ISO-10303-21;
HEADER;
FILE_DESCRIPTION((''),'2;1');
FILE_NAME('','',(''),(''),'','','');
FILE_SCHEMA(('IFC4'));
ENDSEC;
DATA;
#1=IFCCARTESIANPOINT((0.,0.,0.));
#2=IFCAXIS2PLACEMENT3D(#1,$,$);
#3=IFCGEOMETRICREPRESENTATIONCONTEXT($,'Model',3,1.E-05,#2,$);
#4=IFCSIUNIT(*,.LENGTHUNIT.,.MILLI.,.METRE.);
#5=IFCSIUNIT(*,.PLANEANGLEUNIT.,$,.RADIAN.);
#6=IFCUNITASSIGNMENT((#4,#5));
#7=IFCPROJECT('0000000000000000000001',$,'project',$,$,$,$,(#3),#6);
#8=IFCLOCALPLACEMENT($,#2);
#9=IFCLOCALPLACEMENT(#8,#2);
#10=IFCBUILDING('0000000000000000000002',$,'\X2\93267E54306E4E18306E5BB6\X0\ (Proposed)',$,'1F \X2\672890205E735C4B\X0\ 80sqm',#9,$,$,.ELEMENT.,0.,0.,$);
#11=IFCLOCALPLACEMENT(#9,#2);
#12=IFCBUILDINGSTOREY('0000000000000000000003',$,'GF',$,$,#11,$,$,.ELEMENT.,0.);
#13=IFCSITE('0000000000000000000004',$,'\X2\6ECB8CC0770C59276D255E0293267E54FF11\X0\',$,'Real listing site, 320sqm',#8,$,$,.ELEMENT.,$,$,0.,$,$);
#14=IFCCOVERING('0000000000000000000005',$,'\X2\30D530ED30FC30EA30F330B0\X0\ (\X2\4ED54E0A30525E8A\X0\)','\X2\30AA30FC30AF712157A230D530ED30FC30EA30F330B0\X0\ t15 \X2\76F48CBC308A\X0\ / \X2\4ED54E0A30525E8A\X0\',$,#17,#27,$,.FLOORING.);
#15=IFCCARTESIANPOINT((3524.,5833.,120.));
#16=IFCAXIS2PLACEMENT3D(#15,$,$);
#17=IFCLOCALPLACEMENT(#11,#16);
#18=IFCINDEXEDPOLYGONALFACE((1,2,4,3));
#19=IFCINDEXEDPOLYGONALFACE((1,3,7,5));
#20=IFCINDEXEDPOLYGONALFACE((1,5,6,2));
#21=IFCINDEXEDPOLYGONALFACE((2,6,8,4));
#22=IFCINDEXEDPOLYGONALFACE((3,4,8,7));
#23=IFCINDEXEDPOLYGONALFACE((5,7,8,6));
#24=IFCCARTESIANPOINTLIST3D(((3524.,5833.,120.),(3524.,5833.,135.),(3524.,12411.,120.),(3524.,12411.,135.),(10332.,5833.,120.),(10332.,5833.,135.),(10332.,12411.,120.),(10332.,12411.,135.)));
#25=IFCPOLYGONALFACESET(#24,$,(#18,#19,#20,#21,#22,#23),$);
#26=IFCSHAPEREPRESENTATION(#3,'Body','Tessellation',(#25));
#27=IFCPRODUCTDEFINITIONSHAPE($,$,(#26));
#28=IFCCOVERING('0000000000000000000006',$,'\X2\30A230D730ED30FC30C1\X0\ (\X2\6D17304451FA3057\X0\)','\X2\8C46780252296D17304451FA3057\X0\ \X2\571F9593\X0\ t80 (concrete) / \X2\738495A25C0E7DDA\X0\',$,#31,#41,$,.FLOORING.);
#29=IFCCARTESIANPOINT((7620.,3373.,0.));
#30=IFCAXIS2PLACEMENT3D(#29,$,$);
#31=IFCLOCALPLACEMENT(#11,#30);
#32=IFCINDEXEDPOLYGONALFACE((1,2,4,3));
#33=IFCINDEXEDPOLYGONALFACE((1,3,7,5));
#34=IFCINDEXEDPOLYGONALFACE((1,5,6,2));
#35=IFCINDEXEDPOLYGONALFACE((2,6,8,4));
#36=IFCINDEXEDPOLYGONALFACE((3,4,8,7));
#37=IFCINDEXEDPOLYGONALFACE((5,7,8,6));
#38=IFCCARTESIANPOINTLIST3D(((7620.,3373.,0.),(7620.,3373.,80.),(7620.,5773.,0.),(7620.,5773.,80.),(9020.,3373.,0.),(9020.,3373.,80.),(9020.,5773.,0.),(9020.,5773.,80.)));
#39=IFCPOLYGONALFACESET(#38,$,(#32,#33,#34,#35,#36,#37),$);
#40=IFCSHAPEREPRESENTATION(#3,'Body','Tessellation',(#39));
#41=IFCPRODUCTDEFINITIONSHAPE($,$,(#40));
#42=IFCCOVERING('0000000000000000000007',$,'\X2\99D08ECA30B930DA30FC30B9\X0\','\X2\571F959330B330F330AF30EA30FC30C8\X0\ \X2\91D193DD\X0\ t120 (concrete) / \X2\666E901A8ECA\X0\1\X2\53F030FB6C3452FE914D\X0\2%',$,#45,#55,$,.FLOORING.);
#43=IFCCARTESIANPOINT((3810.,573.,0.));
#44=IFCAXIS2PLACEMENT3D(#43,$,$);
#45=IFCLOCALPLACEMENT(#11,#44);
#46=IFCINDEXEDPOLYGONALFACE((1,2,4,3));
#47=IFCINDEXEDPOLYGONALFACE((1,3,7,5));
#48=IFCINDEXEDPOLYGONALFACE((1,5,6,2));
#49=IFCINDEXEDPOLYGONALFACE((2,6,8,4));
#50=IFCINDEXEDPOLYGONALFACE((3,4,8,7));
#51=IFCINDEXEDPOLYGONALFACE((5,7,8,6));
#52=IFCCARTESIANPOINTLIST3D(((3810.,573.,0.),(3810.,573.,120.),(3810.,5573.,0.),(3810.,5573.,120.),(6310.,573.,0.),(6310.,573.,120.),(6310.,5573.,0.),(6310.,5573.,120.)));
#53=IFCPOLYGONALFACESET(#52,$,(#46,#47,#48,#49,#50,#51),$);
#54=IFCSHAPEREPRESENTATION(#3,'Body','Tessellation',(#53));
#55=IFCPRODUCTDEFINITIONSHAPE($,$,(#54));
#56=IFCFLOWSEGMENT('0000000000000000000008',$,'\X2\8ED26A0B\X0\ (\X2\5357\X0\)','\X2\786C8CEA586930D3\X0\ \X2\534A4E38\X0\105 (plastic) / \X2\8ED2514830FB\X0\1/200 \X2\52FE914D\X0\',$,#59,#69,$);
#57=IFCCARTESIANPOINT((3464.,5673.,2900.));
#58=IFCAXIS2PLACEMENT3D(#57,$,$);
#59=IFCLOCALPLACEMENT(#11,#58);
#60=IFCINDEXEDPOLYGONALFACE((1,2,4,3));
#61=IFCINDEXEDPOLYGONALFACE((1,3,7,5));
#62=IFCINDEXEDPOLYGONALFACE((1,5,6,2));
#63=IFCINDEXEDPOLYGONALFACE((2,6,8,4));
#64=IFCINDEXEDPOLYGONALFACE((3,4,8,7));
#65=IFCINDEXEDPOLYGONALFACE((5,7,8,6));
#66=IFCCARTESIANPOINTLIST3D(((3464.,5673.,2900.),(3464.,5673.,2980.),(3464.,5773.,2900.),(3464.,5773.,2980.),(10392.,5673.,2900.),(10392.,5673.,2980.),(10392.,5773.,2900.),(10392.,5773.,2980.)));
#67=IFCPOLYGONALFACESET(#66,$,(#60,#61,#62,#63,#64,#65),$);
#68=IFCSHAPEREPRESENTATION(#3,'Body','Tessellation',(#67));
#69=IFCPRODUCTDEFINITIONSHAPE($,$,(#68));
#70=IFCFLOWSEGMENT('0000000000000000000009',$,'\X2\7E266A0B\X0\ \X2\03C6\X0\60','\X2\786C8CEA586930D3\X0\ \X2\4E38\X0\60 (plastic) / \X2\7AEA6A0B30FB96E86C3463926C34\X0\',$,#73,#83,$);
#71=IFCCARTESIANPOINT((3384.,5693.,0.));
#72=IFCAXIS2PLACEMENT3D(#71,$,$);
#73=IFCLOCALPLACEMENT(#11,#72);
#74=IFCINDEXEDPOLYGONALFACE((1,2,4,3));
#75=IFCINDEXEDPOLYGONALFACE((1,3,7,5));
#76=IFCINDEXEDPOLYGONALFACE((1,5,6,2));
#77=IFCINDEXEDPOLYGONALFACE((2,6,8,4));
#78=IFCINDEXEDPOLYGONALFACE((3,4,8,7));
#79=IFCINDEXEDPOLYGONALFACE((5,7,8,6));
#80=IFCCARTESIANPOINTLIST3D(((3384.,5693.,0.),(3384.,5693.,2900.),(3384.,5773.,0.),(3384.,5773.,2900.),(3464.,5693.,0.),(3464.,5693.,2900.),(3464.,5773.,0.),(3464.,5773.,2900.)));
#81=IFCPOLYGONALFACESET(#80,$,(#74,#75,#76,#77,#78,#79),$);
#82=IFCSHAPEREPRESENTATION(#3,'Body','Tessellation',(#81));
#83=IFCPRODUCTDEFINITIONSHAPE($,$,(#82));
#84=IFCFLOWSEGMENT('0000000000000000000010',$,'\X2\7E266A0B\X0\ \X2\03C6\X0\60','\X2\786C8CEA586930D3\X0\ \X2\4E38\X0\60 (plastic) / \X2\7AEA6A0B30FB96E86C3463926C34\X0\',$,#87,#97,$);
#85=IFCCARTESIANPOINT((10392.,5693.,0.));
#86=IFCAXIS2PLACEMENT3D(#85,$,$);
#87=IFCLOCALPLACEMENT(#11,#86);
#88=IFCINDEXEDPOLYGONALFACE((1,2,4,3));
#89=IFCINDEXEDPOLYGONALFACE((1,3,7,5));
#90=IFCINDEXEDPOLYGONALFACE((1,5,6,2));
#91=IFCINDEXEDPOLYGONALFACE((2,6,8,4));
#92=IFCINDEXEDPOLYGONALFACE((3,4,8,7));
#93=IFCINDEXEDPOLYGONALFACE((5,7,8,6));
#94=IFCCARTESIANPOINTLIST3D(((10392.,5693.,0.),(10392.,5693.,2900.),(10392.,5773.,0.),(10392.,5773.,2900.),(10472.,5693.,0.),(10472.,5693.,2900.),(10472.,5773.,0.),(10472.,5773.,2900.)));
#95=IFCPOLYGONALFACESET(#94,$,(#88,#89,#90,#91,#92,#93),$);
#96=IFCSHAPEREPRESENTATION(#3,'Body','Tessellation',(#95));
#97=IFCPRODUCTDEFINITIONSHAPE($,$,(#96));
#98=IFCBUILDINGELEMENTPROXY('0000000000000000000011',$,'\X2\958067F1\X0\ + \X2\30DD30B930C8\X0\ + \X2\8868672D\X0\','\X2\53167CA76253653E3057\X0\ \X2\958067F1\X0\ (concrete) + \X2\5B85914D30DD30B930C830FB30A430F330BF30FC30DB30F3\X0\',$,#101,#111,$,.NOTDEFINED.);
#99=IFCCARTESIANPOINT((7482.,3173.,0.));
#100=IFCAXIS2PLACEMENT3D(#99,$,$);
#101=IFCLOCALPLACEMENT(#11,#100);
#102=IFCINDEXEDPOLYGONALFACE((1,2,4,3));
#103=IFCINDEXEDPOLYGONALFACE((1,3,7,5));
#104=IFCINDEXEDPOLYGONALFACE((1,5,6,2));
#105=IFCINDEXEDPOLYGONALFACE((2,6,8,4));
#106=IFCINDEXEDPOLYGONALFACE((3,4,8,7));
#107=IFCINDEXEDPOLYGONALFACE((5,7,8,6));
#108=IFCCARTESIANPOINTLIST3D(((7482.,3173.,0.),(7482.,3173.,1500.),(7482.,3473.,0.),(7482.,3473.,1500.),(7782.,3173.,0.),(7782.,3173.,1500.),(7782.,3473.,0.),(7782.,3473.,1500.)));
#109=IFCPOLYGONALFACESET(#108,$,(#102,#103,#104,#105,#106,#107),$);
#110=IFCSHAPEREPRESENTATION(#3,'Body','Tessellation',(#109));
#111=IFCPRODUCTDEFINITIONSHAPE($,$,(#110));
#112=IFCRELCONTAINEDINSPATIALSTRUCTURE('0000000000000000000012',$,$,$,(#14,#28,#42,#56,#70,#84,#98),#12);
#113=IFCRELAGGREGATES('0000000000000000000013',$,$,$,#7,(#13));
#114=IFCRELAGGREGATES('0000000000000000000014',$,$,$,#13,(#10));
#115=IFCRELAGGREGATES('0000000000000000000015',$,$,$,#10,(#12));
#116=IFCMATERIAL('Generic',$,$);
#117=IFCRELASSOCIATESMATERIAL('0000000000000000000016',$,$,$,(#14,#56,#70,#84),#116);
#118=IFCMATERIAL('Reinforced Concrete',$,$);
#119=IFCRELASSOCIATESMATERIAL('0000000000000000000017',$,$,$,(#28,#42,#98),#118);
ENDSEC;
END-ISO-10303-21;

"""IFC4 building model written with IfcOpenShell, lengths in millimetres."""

from ifc_helpers import new_model, si_unit, frame, frame_2d, origin, place, context, project, spatial, rectangle, extrude, material, element, save


model = new_model("IFC4")

# Units and contexts
model_context = context("Model", 3, precision=1e-05, world=origin())
ifc_project = project(units=[si_unit("LENGTHUNIT", "METRE", prefix="MILLI"), si_unit("PLANEANGLEUNIT", "RADIAN")], contexts=[model_context])

# Site, building, storey
site_placement = place(None, origin())
site = spatial("IfcSite", under=ifc_project, at=site_placement, Name="滋賀県大津市錦織１", ObjectType="Real listing site, 320sqm", CompositionType="ELEMENT", RefElevation=0.0)
building_placement = place(site_placement, origin())
building = spatial("IfcBuilding", under=site, at=building_placement, Name="錦織の丘の家 (Proposed)", ObjectType="1F 木造平屋 80sqm", CompositionType="ELEMENT", ElevationOfRefHeight=0.0, ElevationOfTerrain=0.0)
storey_placement = place(building_placement, origin())
storey = spatial("IfcBuildingStorey", under=building, at=storey_placement, Name="GF", CompositionType="ELEMENT", Elevation=0.0)

# Shared definitions
ifc_material_1 = material(Name="Reinforced Concrete")

# Coverings
ifc_material_2 = material(Name="Generic")
covering_1_placement = place(storey_placement, frame((3524.0, 5833.0, 120.0)))
element("IfcCovering", 1, at=covering_1_placement, inside=storey, material=ifc_material_2, Name="フローリング (仕上げ床)", Description="オーク無垢フローリング t15 直貼り / 仕上げ床", PredefinedType="FLOORING", context=model_context, shape_type="SweptSolid", body=[
    extrude(rectangle(XDim=6808.0, YDim=6578.0, at=frame_2d((3404.0, 3289.0))), frame((3524.0, 5833.0, 120.0)), (0.0, 0.0, 1.0), 15.0),
])
covering_2_placement = place(storey_placement, frame((7620.0, 3373.0, 0.0)))
element("IfcCovering", 2, at=covering_2_placement, inside=storey, material=ifc_material_1, Name="アプローチ (洗い出し)", Description="豆砂利洗い出し 土間 t80 (concrete) / 玄関導線", PredefinedType="FLOORING", context=model_context, shape_type="SweptSolid", body=[
    extrude(rectangle(XDim=1400.0, YDim=2400.0, at=frame_2d((700.0, 1200.0))), frame((7620.0, 3373.0, 0.0)), (0.0, 0.0, 1.0), 80.0),
])
covering_3_placement = place(storey_placement, frame((3810.0, 573.0, 0.0)))
element("IfcCovering", 3, at=covering_3_placement, inside=storey, material=ifc_material_1, Name="駐車スペース", Description="土間コンクリート 金鏝 t120 (concrete) / 普通車1台・水勾配2%", PredefinedType="FLOORING", context=model_context, shape_type="SweptSolid", body=[
    extrude(rectangle(XDim=2500.0, YDim=5000.0, at=frame_2d((1250.0, 2500.0))), frame((3810.0, 573.0, 0.0)), (0.0, 0.0, 1.0), 120.0),
])

# Flow segments
flow_segment_1_placement = place(storey_placement, frame((3464.0, 5673.0, 2900.0)))
element("IfcFlowSegment", 4, at=flow_segment_1_placement, inside=storey, material=ifc_material_2, Name="軒樋 (南)", Description="硬質塩ビ 半丸105 (plastic) / 軒先・1/200 勾配", context=model_context, shape_type="SweptSolid", body=[
    extrude(rectangle(XDim=6928.0, YDim=100.0, at=frame_2d((3464.0, 50.0))), frame((3464.0, 5673.0, 2900.0)), (0.0, 0.0, 1.0), 80.0),
])
flow_segment_2_placement = place(storey_placement, frame((3384.0, 5693.0, 0.0)))
element("IfcFlowSegment", 5, at=flow_segment_2_placement, inside=storey, material=ifc_material_2, Name="縦樋 φ60", Description="硬質塩ビ 丸60 (plastic) / 竪樋・雨水排水", context=model_context, shape_type="SweptSolid", body=[
    extrude(rectangle(XDim=80.0, YDim=80.0, at=frame_2d((40.0, 40.0))), frame((3384.0, 5693.0, 0.0)), (0.0, 0.0, 1.0), 2900.0),
])
flow_segment_3_placement = place(storey_placement, frame((10392.0, 5693.0, 0.0)))
element("IfcFlowSegment", 6, at=flow_segment_3_placement, inside=storey, material=ifc_material_2, Name="縦樋 φ60", Description="硬質塩ビ 丸60 (plastic) / 竪樋・雨水排水", context=model_context, shape_type="SweptSolid", body=[
    extrude(rectangle(XDim=80.0, YDim=80.0, at=frame_2d((40.0, 40.0))), frame((10392.0, 5693.0, 0.0)), (0.0, 0.0, 1.0), 2900.0),
])

# Building element proxy
proxy_placement = place(storey_placement, frame((7482.0, 3173.0, 0.0)))
element("IfcBuildingElementProxy", 7, at=proxy_placement, inside=storey, material=ifc_material_1, Name="門柱 + ポスト + 表札", Description="化粧打放し 門柱 (concrete) + 宅配ポスト・インターホン", PredefinedType="NOTDEFINED", context=model_context, shape_type="SweptSolid", body=[
    extrude(rectangle(XDim=300.0, YDim=300.0, at=frame_2d((150.0, 150.0))), frame((7482.0, 3173.0, 0.0)), (0.0, 0.0, 1.0), 1500.0),
])

save(model, "model.ifc")
